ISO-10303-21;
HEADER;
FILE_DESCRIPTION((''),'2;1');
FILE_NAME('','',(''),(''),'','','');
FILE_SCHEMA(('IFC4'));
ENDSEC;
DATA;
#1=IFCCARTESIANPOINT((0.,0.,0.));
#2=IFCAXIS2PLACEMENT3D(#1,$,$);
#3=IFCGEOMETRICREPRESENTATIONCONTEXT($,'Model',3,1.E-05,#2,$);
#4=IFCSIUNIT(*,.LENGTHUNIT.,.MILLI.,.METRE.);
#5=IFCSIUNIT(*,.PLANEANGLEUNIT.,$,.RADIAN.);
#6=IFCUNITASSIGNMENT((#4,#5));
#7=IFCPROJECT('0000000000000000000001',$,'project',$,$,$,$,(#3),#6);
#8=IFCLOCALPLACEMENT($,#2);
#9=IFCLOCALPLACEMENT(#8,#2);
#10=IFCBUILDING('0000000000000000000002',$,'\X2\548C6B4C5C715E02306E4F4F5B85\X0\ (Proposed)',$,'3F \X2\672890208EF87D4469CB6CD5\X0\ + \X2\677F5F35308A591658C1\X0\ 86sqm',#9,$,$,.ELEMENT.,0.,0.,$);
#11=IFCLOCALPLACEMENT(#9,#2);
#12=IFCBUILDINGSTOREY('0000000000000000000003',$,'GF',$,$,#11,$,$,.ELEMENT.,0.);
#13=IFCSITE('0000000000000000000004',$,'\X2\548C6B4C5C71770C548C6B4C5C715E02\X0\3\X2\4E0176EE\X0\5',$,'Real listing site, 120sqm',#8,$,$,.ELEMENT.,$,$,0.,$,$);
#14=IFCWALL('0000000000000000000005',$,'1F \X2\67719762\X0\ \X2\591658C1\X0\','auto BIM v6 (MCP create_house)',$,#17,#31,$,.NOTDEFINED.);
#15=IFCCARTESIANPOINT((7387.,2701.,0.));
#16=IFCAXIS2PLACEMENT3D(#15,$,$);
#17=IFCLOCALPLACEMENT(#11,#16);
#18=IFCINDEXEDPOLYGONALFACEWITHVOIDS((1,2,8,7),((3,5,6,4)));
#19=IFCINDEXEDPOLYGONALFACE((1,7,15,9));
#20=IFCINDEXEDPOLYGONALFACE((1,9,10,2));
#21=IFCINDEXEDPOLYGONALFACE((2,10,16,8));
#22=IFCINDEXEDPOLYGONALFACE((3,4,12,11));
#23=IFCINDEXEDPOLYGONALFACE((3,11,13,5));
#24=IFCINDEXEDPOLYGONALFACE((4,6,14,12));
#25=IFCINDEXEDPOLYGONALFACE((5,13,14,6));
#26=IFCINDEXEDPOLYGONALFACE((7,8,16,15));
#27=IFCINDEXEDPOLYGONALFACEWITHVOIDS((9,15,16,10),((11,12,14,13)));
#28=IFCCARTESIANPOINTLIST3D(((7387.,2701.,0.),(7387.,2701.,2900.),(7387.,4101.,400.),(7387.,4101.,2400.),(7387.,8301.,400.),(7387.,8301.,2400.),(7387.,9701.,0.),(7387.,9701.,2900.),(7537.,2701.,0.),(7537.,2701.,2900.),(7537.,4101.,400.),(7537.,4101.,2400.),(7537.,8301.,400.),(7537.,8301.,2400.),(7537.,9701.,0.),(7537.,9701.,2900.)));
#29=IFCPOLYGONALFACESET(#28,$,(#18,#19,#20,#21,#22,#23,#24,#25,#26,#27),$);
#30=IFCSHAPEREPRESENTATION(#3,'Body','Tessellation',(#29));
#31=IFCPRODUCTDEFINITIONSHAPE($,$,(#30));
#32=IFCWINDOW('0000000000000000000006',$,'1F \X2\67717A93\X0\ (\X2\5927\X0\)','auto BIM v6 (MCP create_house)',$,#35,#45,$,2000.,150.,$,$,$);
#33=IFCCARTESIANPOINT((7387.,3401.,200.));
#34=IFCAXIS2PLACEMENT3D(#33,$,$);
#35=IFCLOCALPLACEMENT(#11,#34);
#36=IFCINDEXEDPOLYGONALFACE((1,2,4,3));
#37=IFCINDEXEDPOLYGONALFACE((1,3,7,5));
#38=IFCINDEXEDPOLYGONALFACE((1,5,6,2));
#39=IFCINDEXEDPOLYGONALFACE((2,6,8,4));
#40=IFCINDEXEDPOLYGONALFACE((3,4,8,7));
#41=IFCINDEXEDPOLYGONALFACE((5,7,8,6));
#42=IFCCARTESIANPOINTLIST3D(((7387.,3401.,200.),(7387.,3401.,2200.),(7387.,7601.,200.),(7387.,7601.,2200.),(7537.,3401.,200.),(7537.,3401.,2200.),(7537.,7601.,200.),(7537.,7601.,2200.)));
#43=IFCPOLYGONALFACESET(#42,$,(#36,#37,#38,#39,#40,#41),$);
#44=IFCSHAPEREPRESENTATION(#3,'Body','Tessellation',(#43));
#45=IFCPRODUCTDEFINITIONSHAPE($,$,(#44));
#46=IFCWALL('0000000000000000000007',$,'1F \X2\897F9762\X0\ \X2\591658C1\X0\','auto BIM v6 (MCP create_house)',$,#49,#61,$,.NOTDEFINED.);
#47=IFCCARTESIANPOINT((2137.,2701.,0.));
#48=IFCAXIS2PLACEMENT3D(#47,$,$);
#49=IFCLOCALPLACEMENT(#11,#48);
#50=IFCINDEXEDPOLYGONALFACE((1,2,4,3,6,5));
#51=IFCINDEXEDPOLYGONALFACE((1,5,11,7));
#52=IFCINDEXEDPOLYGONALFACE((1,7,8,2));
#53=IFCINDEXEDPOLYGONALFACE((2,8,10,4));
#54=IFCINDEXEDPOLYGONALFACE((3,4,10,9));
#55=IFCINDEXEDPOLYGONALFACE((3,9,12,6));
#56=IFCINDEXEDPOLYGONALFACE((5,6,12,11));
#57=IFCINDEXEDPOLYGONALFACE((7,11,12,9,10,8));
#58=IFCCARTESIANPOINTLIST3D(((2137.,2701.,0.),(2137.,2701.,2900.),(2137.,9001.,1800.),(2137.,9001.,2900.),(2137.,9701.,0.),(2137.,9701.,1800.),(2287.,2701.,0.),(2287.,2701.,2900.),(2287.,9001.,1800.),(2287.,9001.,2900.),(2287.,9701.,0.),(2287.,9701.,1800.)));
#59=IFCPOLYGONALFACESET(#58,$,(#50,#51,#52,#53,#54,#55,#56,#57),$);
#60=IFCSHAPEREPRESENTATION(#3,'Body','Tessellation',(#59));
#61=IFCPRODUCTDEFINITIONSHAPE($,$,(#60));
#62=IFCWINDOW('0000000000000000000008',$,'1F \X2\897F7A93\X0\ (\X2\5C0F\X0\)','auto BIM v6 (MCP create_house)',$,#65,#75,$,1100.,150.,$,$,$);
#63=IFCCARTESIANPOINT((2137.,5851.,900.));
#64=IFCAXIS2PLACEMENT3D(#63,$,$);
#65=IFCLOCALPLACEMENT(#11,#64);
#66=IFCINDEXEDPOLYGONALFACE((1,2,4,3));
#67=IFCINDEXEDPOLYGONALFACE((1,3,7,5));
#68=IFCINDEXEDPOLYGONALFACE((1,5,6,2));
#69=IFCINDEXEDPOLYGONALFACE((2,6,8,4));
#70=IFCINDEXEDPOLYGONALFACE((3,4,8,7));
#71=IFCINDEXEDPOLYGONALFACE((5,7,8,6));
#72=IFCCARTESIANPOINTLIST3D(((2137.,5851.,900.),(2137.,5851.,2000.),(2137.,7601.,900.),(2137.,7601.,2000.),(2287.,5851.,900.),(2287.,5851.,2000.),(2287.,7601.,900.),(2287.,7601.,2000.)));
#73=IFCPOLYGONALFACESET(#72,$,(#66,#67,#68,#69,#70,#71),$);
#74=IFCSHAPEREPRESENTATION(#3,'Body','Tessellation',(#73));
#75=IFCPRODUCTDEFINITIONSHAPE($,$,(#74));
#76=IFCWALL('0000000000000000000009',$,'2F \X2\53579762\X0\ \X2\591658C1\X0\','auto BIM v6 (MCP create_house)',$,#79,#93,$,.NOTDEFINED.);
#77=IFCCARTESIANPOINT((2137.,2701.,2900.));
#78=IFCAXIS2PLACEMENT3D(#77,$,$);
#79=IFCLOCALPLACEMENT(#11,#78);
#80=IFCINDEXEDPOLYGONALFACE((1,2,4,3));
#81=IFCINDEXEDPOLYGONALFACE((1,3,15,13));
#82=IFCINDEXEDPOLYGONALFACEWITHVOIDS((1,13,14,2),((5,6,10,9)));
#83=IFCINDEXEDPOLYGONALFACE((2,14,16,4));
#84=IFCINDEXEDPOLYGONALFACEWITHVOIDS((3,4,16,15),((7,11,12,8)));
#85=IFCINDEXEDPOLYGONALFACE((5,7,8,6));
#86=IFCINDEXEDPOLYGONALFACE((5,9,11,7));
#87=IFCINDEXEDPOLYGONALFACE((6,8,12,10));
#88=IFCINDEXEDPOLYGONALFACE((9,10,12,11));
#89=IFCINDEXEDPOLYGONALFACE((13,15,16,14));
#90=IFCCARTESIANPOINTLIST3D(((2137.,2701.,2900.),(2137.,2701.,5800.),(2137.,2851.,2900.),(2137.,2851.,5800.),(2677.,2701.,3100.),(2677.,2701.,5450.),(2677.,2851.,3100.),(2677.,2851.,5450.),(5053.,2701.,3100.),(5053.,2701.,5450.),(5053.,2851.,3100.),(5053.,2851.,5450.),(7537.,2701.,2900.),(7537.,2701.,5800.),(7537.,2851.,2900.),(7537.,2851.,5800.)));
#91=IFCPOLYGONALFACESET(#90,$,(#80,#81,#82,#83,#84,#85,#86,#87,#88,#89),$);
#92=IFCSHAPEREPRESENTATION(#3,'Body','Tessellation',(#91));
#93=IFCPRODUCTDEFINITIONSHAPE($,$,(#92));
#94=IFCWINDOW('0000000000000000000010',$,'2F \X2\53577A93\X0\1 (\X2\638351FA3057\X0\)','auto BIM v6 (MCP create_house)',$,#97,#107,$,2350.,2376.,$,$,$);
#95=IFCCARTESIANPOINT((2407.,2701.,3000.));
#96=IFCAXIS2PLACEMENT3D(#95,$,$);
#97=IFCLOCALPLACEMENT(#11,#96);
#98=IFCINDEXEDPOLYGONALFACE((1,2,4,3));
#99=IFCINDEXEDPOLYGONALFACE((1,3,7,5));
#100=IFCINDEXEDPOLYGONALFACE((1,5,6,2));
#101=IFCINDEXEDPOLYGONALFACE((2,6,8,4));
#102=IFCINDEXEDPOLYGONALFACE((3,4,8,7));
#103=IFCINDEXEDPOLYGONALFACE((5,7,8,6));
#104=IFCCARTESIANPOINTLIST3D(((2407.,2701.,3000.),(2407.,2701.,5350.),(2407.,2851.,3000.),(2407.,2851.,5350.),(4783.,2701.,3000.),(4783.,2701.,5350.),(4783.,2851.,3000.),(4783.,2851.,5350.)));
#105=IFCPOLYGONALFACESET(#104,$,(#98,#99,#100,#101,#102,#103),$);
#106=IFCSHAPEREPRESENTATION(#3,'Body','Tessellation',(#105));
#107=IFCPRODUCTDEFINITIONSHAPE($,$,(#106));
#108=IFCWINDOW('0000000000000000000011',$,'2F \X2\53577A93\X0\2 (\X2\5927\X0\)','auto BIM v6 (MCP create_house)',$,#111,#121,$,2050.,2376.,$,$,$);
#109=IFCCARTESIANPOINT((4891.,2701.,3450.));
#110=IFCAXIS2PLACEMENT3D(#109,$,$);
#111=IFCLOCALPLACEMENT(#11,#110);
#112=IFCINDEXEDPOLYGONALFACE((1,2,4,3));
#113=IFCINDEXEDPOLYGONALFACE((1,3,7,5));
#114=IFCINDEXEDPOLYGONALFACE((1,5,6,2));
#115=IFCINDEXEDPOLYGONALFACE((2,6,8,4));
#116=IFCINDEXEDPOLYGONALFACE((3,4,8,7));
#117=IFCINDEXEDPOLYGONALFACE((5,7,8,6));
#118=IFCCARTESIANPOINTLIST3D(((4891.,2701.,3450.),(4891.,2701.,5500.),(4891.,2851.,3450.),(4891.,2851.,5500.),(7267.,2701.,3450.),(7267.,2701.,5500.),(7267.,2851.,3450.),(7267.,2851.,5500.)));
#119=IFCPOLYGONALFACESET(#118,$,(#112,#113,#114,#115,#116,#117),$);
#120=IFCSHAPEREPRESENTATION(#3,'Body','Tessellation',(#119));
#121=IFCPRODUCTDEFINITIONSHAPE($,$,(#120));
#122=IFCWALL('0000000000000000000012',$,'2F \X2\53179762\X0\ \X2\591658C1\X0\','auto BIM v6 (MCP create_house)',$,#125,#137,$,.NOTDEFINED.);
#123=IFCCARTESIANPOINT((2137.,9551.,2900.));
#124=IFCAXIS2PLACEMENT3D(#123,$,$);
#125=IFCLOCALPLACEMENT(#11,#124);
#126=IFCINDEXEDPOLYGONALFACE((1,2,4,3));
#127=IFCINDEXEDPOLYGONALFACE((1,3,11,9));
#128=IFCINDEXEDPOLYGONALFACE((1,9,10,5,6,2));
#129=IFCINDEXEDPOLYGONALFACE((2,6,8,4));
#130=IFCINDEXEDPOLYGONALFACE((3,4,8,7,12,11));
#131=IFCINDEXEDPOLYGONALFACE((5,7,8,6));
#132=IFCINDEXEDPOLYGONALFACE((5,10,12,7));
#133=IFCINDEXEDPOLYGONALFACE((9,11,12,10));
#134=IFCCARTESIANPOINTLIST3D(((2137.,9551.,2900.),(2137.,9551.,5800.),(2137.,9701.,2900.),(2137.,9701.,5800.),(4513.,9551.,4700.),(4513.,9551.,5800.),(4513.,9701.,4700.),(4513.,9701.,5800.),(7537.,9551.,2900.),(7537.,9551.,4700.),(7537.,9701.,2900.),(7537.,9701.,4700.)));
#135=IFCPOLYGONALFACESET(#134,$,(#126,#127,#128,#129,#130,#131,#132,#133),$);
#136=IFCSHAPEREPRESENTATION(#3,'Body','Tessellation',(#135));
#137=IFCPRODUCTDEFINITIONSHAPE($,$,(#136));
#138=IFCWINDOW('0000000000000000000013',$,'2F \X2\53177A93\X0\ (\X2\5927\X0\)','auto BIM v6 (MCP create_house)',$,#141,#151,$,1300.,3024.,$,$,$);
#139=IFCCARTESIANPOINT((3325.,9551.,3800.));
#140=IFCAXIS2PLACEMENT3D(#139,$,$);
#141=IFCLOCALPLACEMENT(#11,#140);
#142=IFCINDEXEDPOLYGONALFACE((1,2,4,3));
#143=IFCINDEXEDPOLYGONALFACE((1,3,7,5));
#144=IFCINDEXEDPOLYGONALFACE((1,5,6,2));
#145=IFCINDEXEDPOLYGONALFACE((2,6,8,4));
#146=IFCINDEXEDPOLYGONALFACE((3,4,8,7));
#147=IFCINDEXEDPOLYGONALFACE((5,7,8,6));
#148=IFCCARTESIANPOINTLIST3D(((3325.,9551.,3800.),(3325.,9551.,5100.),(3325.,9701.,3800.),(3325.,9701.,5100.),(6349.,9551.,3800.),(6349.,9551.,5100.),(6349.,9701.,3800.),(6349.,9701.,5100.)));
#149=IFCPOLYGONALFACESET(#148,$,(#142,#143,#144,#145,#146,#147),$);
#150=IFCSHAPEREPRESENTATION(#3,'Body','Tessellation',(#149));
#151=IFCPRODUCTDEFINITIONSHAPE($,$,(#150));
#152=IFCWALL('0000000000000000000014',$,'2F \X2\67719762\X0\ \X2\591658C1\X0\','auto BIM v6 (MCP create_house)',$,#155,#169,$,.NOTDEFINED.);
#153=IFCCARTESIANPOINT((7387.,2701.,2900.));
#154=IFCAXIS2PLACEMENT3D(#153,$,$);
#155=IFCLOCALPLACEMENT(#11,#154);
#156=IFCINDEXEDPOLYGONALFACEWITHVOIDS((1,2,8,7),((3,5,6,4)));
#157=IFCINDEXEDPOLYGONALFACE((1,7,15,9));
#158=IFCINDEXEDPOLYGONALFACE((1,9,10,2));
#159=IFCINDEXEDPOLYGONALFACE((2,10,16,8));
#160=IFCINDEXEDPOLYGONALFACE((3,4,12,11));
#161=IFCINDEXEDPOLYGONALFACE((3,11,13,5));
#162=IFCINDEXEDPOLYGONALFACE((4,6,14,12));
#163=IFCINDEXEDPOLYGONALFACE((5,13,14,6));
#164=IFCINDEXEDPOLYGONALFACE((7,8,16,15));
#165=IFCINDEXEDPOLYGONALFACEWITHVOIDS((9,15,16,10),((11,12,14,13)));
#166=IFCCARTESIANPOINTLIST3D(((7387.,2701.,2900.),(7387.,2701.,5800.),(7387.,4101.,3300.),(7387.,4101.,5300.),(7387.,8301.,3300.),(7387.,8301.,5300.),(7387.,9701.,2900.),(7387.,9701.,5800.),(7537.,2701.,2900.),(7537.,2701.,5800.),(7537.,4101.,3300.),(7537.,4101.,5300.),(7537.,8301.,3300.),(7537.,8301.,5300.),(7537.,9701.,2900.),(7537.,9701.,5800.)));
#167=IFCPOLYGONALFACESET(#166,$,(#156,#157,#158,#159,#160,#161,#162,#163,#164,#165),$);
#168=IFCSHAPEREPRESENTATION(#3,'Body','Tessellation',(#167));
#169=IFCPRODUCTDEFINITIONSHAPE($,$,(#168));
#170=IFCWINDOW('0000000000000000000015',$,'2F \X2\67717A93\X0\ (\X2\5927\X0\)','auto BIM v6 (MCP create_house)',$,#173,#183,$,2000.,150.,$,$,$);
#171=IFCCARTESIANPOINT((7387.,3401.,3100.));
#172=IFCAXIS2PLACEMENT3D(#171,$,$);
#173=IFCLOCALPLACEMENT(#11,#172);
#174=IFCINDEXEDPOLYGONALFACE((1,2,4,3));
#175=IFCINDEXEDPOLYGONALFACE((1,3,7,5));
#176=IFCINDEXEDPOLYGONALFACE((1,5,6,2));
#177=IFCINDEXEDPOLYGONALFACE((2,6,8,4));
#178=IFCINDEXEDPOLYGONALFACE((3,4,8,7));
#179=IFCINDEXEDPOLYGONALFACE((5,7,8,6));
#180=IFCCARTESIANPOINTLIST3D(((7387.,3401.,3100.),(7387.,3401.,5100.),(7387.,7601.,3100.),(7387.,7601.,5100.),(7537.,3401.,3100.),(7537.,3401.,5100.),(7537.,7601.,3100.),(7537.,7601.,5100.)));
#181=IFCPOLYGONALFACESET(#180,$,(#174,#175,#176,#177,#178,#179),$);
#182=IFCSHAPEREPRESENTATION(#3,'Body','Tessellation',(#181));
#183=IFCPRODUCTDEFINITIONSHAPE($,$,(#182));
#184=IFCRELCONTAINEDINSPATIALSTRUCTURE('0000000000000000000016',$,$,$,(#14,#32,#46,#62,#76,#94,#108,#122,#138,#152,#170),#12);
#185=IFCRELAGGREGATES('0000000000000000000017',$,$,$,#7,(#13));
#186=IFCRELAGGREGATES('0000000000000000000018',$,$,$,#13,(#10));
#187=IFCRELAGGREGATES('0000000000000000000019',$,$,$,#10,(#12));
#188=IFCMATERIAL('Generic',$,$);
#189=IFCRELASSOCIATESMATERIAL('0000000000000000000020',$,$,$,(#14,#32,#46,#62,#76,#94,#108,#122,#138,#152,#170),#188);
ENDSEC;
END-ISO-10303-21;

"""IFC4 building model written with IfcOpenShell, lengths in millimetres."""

from ifc_helpers import new_model, si_unit, frame, frame_2d, origin, place, context, project, spatial, rectangle, extrude, material, element, fill, save


model = new_model("IFC4")

# Units and contexts
model_context = context("Model", 3, precision=1e-05, world=origin())
ifc_project = project(units=[si_unit("LENGTHUNIT", "METRE", prefix="MILLI"), si_unit("PLANEANGLEUNIT", "RADIAN")], contexts=[model_context])

# Site, building, storey
site_placement = place(None, origin())
site = spatial("IfcSite", under=ifc_project, at=site_placement, Name="和歌山県和歌山市3丁目5", ObjectType="Real listing site, 120sqm", CompositionType="ELEMENT", RefElevation=0.0)
building_placement = place(site_placement, origin())
building = spatial("IfcBuilding", under=site, at=building_placement, Name="和歌山市の住宅 (Proposed)", ObjectType="3F 木造軸組構法 + 板張り外壁 86sqm", CompositionType="ELEMENT", ElevationOfRefHeight=0.0, ElevationOfTerrain=0.0)
storey_placement = place(building_placement, origin())
storey = spatial("IfcBuildingStorey", under=building, at=storey_placement, Name="GF", CompositionType="ELEMENT", Elevation=0.0)

# Shared definitions
ifc_material = material(Name="Generic")

# Walls, openings, windows
wall_1_placement = place(storey_placement, frame((7387.0, 2701.0, 0.0)))
wall_1 = element("IfcWall", 1, at=wall_1_placement, inside=storey, material=ifc_material, Name="1F 東面 外壁", Description="auto BIM v6 (MCP create_house)", PredefinedType="NOTDEFINED", context=model_context, shape_type="SweptSolid", body=[
    extrude(rectangle(XDim=150.0, YDim=7000.0, at=frame_2d((75.0, 3500.0))), frame((7387.0, 2701.0, 0.0)), (0.0, 0.0, 1.0), 2900.0),
])
opening_1_placement = place(storey_placement, frame((7387.0, 3401.0, 200.0)))
opening_1 = element("IfcOpeningElement", 2, at=opening_1_placement, cuts=wall_1, PredefinedType="NOTDEFINED", context=model_context, shape_type="SweptSolid", body=[
    extrude(rectangle(XDim=150.0, YDim=4200.0, at=frame_2d((75.0, 2100.0))), frame((7387.0, 3401.0, 200.0)), (0.0, 0.0, 1.0), 2000.0),
])
window_1_placement = place(storey_placement, frame((7387.0, 3401.0, 200.0)))
window_1 = element("IfcWindow", 3, at=window_1_placement, inside=storey, material=ifc_material, Name="1F 東窓 (大)", Description="auto BIM v6 (MCP create_house)", OverallHeight=2000.0, OverallWidth=150.0, context=model_context, shape_type="SweptSolid", body=[
    extrude(rectangle(XDim=150.0, YDim=4200.0, at=frame_2d((75.0, 2100.0))), frame((7387.0, 3401.0, 200.0)), (0.0, 0.0, 1.0), 2000.0),
])
fill(opening_1, window_1)
wall_2_placement = place(storey_placement, frame((2137.0, 2701.0, 0.0)))
wall_2 = element("IfcWall", 4, at=wall_2_placement, inside=storey, material=ifc_material, Name="1F 西面 外壁", Description="auto BIM v6 (MCP create_house)", PredefinedType="NOTDEFINED", context=model_context, shape_type="SweptSolid", body=[
    extrude(rectangle(XDim=150.0, YDim=7000.0, at=frame_2d((75.0, 3500.0))), frame((2137.0, 2701.0, 0.0)), (0.0, 0.0, 1.0), 2900.0),
])
opening_2_placement = place(storey_placement, frame((2137.0, 5851.0, 900.0)))
opening_2 = element("IfcOpeningElement", 5, at=opening_2_placement, cuts=wall_2, PredefinedType="NOTDEFINED", context=model_context, shape_type="SweptSolid", body=[
    extrude(rectangle(XDim=150.0, YDim=1750.0, at=frame_2d((75.0, 875.0))), frame((2137.0, 5851.0, 900.0)), (0.0, 0.0, 1.0), 1100.0),
])
window_2_placement = place(storey_placement, frame((2137.0, 5851.0, 900.0)))
window_2 = element("IfcWindow", 6, at=window_2_placement, inside=storey, material=ifc_material, Name="1F 西窓 (小)", Description="auto BIM v6 (MCP create_house)", OverallHeight=1100.0, OverallWidth=150.0, context=model_context, shape_type="SweptSolid", body=[
    extrude(rectangle(XDim=150.0, YDim=1750.0, at=frame_2d((75.0, 875.0))), frame((2137.0, 5851.0, 900.0)), (0.0, 0.0, 1.0), 1100.0),
])
fill(opening_2, window_2)

# Wall, openings, windows
wall_3_placement = place(storey_placement, frame((2137.0, 2701.0, 2900.0)))
wall_3 = element("IfcWall", 7, at=wall_3_placement, inside=storey, material=ifc_material, Name="2F 南面 外壁", Description="auto BIM v6 (MCP create_house)", PredefinedType="NOTDEFINED", context=model_context, shape_type="SweptSolid", body=[
    extrude(rectangle(XDim=5400.0, YDim=150.0, at=frame_2d((2700.0, 75.0))), frame((2137.0, 2701.0, 2900.0)), (0.0, 0.0, 1.0), 2900.0),
])
opening_3_placement = place(storey_placement, frame((2407.0, 2701.0, 3000.0)))
opening_3 = element("IfcOpeningElement", 8, at=opening_3_placement, cuts=wall_3, PredefinedType="NOTDEFINED", context=model_context, shape_type="SweptSolid", body=[
    extrude(rectangle(XDim=2376.0, YDim=150.0, at=frame_2d((1188.0, 75.0))), frame((2407.0, 2701.0, 3000.0)), (0.0, 0.0, 1.0), 2350.0),
])
opening_4_placement = place(storey_placement, frame((4891.0, 2701.0, 3450.0)))
opening_4 = element("IfcOpeningElement", 9, at=opening_4_placement, cuts=wall_3, PredefinedType="NOTDEFINED", context=model_context, shape_type="SweptSolid", body=[
    extrude(rectangle(XDim=2376.0, YDim=150.0, at=frame_2d((1188.0, 75.0))), frame((4891.0, 2701.0, 3450.0)), (0.0, 0.0, 1.0), 2050.0),
])
window_3_placement = place(storey_placement, frame((2407.0, 2701.0, 3000.0)))
window_3 = element("IfcWindow", 10, at=window_3_placement, inside=storey, material=ifc_material, Name="2F 南窓1 (掃出し)", Description="auto BIM v6 (MCP create_house)", OverallHeight=2350.0, OverallWidth=2376.0, context=model_context, shape_type="SweptSolid", body=[
    extrude(rectangle(XDim=2376.0, YDim=150.0, at=frame_2d((1188.0, 75.0))), frame((2407.0, 2701.0, 3000.0)), (0.0, 0.0, 1.0), 2350.0),
])
fill(opening_3, window_3)
window_4_placement = place(storey_placement, frame((4891.0, 2701.0, 3450.0)))
window_4 = element("IfcWindow", 11, at=window_4_placement, inside=storey, material=ifc_material, Name="2F 南窓2 (大)", Description="auto BIM v6 (MCP create_house)", OverallHeight=2050.0, OverallWidth=2376.0, context=model_context, shape_type="SweptSolid", body=[
    extrude(rectangle(XDim=2376.0, YDim=150.0, at=frame_2d((1188.0, 75.0))), frame((4891.0, 2701.0, 3450.0)), (0.0, 0.0, 1.0), 2050.0),
])
fill(opening_4, window_4)

# Walls, openings, windows
wall_4_placement = place(storey_placement, frame((2137.0, 9551.0, 2900.0)))
wall_4 = element("IfcWall", 12, at=wall_4_placement, inside=storey, material=ifc_material, Name="2F 北面 外壁", Description="auto BIM v6 (MCP create_house)", PredefinedType="NOTDEFINED", context=model_context, shape_type="SweptSolid", body=[
    extrude(rectangle(XDim=5400.0, YDim=150.0, at=frame_2d((2700.0, 75.0))), frame((2137.0, 9551.0, 2900.0)), (0.0, 0.0, 1.0), 2900.0),
])
opening_5_placement = place(storey_placement, frame((3325.0, 9551.0, 3800.0)))
opening_5 = element("IfcOpeningElement", 13, at=opening_5_placement, cuts=wall_4, PredefinedType="NOTDEFINED", context=model_context, shape_type="SweptSolid", body=[
    extrude(rectangle(XDim=3024.0, YDim=150.0, at=frame_2d((1512.0, 75.0))), frame((3325.0, 9551.0, 3800.0)), (0.0, 0.0, 1.0), 1300.0),
])
window_5_placement = place(storey_placement, frame((3325.0, 9551.0, 3800.0)))
window_5 = element("IfcWindow", 14, at=window_5_placement, inside=storey, material=ifc_material, Name="2F 北窓 (大)", Description="auto BIM v6 (MCP create_house)", OverallHeight=1300.0, OverallWidth=3024.0, context=model_context, shape_type="SweptSolid", body=[
    extrude(rectangle(XDim=3024.0, YDim=150.0, at=frame_2d((1512.0, 75.0))), frame((3325.0, 9551.0, 3800.0)), (0.0, 0.0, 1.0), 1300.0),
])
fill(opening_5, window_5)
wall_5_placement = place(storey_placement, frame((7387.0, 2701.0, 2900.0)))
wall_5 = element("IfcWall", 15, at=wall_5_placement, inside=storey, material=ifc_material, Name="2F 東面 外壁", Description="auto BIM v6 (MCP create_house)", PredefinedType="NOTDEFINED", context=model_context, shape_type="SweptSolid", body=[
    extrude(rectangle(XDim=150.0, YDim=7000.0, at=frame_2d((75.0, 3500.0))), frame((7387.0, 2701.0, 2900.0)), (0.0, 0.0, 1.0), 2900.0),
])
opening_6_placement = place(storey_placement, frame((7387.0, 3401.0, 3100.0)))
opening_6 = element("IfcOpeningElement", 16, at=opening_6_placement, cuts=wall_5, PredefinedType="NOTDEFINED", context=model_context, shape_type="SweptSolid", body=[
    extrude(rectangle(XDim=150.0, YDim=4200.0, at=frame_2d((75.0, 2100.0))), frame((7387.0, 3401.0, 3100.0)), (0.0, 0.0, 1.0), 2000.0),
])
window_6_placement = place(storey_placement, frame((7387.0, 3401.0, 3100.0)))
window_6 = element("IfcWindow", 17, at=window_6_placement, inside=storey, material=ifc_material, Name="2F 東窓 (大)", Description="auto BIM v6 (MCP create_house)", OverallHeight=2000.0, OverallWidth=150.0, context=model_context, shape_type="SweptSolid", body=[
    extrude(rectangle(XDim=150.0, YDim=4200.0, at=frame_2d((75.0, 2100.0))), frame((7387.0, 3401.0, 3100.0)), (0.0, 0.0, 1.0), 2000.0),
])
fill(opening_6, window_6)

save(model, "model.ifc")
